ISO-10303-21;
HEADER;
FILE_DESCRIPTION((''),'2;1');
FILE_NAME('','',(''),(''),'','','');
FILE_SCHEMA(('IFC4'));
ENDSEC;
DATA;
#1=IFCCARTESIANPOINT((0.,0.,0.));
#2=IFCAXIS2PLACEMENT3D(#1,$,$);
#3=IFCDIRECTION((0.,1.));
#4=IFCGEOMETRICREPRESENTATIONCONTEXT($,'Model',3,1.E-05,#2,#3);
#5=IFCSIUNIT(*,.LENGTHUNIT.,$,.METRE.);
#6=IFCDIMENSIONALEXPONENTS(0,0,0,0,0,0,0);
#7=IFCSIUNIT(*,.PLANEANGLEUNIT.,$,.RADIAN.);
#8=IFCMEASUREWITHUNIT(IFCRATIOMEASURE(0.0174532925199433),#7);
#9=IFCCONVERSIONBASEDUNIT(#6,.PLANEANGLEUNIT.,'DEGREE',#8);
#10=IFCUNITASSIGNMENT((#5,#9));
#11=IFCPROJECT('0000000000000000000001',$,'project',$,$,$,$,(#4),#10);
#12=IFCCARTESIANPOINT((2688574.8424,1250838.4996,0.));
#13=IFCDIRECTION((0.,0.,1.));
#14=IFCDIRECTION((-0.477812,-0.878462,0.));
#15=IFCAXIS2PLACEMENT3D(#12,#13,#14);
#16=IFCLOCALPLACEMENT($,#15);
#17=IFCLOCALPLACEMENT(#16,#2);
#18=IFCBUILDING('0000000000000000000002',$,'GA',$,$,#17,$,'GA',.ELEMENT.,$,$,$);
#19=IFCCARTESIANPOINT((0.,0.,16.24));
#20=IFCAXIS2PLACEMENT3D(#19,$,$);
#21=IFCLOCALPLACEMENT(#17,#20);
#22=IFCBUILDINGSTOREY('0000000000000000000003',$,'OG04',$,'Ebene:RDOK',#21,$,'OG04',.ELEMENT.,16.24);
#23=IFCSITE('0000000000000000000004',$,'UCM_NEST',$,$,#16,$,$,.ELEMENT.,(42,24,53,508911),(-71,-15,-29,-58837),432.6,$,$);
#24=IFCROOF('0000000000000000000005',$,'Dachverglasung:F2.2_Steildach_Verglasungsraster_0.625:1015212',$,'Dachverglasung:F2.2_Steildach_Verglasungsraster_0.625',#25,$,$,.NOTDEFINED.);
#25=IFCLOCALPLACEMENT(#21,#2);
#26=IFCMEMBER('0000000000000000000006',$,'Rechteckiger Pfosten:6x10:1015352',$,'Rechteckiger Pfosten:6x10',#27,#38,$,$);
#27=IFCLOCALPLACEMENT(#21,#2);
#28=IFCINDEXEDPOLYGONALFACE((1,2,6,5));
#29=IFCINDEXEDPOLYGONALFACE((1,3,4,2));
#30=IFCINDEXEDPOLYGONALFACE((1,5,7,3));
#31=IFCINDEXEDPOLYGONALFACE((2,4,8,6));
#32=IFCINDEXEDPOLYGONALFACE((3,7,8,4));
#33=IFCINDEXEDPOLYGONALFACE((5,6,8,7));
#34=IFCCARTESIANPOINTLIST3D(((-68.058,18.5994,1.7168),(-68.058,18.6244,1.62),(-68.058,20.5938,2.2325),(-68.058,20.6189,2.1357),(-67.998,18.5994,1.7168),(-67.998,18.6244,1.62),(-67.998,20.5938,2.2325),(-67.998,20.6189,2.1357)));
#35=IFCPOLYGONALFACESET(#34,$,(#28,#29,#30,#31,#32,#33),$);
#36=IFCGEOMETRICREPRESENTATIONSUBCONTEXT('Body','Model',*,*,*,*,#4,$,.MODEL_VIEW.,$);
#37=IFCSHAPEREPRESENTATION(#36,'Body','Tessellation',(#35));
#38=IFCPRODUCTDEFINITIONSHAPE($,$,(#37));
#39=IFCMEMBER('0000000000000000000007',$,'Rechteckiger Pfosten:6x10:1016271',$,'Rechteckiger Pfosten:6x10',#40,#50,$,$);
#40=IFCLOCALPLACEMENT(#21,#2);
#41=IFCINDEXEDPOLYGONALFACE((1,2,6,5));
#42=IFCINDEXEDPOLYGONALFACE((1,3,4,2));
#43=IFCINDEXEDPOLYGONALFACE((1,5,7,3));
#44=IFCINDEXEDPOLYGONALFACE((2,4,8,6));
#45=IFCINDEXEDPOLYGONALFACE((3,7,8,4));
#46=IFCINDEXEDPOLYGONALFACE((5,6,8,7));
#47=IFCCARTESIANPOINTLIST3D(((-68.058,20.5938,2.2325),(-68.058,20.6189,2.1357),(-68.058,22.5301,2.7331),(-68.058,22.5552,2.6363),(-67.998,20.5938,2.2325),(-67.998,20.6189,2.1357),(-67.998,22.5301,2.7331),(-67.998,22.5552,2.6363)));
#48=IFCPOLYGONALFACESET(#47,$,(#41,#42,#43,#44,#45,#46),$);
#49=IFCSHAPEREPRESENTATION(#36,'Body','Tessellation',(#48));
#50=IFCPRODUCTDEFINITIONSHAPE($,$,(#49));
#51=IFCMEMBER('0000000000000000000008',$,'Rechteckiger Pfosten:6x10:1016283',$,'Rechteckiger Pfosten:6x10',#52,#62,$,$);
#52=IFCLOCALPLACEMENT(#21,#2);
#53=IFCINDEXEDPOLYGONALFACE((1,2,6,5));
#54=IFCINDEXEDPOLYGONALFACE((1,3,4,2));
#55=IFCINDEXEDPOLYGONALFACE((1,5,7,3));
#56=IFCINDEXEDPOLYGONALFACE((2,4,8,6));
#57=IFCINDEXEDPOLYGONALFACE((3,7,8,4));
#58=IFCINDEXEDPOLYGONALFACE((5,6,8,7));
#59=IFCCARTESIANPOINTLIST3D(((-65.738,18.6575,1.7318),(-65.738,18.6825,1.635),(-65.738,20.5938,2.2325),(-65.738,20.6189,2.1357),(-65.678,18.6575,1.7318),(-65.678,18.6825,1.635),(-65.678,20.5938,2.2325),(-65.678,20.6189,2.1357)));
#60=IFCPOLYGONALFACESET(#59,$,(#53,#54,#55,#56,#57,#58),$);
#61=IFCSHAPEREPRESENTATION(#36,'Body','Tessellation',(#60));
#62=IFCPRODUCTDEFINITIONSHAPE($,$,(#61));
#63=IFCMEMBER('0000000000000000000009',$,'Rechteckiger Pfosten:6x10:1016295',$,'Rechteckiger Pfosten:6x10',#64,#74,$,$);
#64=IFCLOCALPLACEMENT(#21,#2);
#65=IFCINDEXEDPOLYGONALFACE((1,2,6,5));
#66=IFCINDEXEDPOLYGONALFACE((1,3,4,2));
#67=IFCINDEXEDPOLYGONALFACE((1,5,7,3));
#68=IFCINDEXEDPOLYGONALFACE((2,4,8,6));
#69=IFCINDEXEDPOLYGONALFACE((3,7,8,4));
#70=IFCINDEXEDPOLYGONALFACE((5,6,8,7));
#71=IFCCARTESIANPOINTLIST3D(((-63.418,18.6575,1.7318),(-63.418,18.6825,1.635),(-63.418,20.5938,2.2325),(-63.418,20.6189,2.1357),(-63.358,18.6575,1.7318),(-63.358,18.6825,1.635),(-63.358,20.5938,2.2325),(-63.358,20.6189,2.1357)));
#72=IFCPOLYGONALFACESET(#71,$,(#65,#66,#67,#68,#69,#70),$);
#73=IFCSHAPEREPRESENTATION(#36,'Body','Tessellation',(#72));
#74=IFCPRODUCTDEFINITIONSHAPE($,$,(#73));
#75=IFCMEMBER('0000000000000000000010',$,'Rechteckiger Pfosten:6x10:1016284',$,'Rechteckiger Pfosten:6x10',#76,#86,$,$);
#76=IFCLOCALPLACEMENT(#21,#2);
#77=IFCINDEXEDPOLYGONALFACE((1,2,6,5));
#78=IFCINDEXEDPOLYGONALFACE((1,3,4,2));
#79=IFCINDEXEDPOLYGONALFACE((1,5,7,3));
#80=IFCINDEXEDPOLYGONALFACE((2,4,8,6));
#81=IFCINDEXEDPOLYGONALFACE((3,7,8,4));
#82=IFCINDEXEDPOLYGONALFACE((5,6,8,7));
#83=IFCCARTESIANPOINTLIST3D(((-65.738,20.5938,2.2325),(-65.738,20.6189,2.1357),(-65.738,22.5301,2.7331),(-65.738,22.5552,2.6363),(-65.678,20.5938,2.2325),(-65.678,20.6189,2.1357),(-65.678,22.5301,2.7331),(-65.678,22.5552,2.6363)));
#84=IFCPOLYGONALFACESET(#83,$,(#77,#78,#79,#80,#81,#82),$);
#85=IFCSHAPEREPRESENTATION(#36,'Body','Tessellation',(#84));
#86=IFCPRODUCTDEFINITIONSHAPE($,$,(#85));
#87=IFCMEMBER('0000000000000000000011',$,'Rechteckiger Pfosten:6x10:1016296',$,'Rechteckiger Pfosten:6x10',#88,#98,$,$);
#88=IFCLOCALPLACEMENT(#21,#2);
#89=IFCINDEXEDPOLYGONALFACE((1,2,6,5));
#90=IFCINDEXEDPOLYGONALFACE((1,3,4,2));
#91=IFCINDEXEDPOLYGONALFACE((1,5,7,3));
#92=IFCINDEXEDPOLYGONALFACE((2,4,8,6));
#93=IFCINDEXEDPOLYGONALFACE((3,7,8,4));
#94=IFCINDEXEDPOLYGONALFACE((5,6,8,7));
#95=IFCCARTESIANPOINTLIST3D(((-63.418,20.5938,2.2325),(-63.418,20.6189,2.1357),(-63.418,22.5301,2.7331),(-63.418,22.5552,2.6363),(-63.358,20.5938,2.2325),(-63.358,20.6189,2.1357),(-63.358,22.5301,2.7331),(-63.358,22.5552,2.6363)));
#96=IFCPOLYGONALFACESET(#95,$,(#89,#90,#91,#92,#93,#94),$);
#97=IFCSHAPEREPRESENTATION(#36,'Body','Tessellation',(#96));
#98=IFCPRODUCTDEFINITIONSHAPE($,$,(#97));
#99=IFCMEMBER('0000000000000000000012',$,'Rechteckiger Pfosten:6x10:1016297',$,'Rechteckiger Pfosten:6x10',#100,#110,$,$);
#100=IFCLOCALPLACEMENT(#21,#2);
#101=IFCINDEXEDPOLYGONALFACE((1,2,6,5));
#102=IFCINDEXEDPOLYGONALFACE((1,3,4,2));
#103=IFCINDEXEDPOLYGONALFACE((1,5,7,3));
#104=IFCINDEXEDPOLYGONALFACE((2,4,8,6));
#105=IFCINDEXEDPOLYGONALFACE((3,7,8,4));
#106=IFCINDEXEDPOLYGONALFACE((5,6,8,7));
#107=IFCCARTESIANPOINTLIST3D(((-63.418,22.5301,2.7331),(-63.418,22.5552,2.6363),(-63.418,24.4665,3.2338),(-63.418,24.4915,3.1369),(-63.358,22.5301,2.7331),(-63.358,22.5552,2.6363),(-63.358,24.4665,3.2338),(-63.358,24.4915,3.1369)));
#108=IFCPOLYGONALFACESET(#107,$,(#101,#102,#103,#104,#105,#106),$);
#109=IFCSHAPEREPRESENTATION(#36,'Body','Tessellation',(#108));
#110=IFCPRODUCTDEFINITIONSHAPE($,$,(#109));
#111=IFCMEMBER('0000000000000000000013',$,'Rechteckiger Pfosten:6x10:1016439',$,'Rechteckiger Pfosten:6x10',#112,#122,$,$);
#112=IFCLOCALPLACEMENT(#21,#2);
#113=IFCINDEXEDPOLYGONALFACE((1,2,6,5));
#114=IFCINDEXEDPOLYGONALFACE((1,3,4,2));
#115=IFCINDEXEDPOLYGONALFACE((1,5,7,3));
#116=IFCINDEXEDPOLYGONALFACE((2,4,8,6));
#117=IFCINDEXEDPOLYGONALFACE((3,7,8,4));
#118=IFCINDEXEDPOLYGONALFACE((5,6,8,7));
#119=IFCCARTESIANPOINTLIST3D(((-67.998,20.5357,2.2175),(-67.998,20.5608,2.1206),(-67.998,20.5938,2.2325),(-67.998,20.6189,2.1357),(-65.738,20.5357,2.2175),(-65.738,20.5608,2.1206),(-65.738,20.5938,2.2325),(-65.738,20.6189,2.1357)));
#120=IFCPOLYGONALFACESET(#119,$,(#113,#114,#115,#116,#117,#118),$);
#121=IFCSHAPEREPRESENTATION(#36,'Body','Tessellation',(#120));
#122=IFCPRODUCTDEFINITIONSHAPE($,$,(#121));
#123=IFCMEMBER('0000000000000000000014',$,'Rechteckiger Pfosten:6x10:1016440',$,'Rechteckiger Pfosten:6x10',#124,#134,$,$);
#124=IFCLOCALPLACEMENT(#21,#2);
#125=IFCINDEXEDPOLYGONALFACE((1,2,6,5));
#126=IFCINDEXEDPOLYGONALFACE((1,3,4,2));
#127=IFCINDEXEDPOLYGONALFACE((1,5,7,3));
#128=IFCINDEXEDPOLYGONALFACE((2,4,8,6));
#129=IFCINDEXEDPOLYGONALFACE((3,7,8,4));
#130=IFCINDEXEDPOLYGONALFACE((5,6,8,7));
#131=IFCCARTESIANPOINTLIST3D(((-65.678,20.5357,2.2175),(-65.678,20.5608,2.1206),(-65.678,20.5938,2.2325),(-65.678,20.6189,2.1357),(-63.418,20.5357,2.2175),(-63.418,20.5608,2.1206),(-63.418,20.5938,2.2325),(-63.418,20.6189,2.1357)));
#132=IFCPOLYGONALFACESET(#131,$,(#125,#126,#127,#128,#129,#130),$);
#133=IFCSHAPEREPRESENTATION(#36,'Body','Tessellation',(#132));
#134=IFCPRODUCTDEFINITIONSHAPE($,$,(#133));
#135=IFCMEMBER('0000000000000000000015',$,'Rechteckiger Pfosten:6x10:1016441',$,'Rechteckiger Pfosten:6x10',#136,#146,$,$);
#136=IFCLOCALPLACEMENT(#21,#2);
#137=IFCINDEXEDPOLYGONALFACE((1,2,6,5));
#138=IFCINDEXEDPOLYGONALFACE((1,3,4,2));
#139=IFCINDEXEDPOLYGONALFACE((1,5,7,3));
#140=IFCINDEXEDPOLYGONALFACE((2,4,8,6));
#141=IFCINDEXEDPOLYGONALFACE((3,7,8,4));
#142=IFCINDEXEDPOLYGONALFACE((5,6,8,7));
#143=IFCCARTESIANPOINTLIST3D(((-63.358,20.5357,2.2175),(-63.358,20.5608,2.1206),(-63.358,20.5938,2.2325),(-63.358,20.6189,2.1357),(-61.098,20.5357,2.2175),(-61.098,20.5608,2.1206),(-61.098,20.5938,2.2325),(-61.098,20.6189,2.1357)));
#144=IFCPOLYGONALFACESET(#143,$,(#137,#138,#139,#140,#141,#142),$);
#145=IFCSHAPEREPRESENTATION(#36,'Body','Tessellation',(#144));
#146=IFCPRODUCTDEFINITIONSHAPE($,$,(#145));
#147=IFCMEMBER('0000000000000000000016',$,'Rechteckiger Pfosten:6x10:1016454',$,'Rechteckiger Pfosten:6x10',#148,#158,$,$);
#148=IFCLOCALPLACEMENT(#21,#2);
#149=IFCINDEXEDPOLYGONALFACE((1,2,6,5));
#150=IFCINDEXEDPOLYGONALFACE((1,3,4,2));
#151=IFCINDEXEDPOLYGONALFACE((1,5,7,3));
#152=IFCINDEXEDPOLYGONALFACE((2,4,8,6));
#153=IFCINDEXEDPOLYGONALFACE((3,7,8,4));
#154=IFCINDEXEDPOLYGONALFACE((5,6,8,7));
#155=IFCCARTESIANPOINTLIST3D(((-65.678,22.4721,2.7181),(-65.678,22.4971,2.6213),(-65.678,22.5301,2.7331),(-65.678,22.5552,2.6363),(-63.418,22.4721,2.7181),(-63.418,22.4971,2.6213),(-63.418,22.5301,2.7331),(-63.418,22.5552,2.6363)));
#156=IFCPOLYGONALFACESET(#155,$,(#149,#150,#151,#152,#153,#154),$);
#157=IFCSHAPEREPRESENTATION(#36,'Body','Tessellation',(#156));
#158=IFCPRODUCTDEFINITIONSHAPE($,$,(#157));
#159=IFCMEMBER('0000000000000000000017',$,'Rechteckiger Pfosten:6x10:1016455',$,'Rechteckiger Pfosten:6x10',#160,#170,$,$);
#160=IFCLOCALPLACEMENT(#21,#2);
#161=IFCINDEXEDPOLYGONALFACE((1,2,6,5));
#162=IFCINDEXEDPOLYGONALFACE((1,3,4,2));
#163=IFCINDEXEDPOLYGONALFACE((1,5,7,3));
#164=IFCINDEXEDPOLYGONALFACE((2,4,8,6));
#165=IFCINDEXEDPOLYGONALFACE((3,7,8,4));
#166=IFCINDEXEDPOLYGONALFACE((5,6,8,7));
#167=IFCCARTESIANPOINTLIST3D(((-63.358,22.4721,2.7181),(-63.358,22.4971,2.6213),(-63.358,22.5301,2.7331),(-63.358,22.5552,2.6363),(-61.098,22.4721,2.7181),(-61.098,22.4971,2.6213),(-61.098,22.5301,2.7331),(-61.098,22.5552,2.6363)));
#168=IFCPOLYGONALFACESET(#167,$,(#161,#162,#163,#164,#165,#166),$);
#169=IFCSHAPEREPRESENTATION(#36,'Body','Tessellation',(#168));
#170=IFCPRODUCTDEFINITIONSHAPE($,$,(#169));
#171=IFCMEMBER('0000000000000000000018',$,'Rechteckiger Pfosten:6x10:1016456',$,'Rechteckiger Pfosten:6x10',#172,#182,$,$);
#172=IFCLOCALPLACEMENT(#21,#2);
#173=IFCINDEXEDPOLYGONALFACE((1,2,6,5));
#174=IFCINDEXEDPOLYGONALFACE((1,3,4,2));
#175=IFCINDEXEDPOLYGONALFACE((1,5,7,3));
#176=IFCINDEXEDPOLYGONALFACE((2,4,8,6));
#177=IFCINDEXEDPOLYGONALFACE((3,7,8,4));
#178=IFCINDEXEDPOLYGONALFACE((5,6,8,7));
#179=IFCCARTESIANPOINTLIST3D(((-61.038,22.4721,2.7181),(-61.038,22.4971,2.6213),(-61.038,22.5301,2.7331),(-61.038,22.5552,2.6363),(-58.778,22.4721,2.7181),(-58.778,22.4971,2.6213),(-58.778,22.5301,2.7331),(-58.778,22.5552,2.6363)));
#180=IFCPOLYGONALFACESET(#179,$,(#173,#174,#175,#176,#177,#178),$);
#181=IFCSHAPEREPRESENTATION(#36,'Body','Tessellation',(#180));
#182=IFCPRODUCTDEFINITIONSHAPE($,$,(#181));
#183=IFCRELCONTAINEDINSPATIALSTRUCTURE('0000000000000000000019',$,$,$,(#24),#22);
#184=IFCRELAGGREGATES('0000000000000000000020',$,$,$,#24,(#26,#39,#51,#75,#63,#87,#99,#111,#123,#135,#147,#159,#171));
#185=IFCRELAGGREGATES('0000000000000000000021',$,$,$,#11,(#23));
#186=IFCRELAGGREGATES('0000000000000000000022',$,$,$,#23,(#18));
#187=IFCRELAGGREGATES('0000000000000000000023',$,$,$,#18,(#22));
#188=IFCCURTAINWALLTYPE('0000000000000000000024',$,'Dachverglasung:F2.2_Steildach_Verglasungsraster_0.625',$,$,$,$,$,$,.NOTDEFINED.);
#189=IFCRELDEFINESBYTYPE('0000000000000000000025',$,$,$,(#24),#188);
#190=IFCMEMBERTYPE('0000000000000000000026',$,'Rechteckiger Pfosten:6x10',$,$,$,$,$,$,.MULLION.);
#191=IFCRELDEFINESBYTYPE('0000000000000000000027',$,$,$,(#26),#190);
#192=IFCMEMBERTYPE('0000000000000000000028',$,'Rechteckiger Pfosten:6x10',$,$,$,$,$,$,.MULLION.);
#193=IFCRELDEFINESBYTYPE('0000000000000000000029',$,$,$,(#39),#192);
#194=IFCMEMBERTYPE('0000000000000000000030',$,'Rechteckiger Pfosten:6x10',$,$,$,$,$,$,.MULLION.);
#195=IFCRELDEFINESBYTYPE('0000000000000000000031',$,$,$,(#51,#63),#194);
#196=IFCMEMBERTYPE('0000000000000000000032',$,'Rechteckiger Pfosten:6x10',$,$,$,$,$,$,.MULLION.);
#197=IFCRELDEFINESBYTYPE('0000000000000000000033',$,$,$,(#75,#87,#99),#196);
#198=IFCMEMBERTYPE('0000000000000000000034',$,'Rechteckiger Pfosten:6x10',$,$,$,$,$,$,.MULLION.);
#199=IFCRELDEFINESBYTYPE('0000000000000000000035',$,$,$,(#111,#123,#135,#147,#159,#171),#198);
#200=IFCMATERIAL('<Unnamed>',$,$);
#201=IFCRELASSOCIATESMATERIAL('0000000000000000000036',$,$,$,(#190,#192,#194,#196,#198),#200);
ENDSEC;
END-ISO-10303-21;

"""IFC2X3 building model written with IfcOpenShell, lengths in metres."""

from ifc_helpers import new_model, entity, si_unit, converted_unit, direction, frame, origin, origin_2d_with_axis, place, context, subcontext, project, spatial, rectangle, extrude, source, transform, mapped, material, type_object, type_shapes, element, aggregate, save


model = new_model("IFC2X3")

# Units and contexts
model_context = context("Model", 3, precision=1e-05, world=origin(), true_north=direction((0.0, 1.0)))
body_context = subcontext(model_context, "Body", "Model", "MODEL_VIEW")
ifc_project = project(units=[si_unit("LENGTHUNIT", "METRE"), converted_unit("PLANEANGLEUNIT", "DEGREE", entity("IfcRatioMeasure", 0.0174532925199433), si_unit("PLANEANGLEUNIT", "RADIAN"), dimensions=[0, 0, 0, 0, 0, 0, 0])], contexts=[model_context])

# Site, building, storey
site_placement = place(None, frame((2688574.8424, 1250838.4996, 0.0), z_axis=(0.0, 0.0, 1.0), x_axis=(-0.477812, -0.878462, 0.0)))
site = spatial("IfcSite", under=ifc_project, at=site_placement, Name="UCM_NEST", CompositionType="ELEMENT", RefLatitude=(42, 24, 53, 508911), RefLongitude=(-71, -15, -29, -58837), RefElevation=432.6)
building_placement = place(site_placement, origin())
building = spatial("IfcBuilding", under=site, at=building_placement, Name="GA", LongName="GA", CompositionType="ELEMENT")
storey_placement = place(building_placement, frame((0.0, 0.0, 16.24)))
storey = spatial("IfcBuildingStorey", under=building, at=storey_placement, Name="OG04", ObjectType="Ebene:RDOK", LongName="OG04", CompositionType="ELEMENT", Elevation=16.24)

# Roof, members
curtain_wall_type = type_object("IfcCurtainWallType", Name="Dachverglasung:F2.2_Steildach_Verglasungsraster_0.625", PredefinedType="NOTDEFINED")
roof_placement = place(storey_placement, frame((0.0, 0.0, -16.24)))
roof = element("IfcRoof", 1, at=roof_placement, inside=storey, type_object=curtain_wall_type, Name="Dachverglasung:F2.2_Steildach_Verglasungsraster_0.625:1015212", ObjectType="Dachverglasung:F2.2_Steildach_Verglasungsraster_0.625", ShapeType="NOTDEFINED")
ifc_material_1 = material(Name="<Unnamed>")
member_type_1 = type_object("IfcMemberType", Name="Rechteckiger Pfosten:6x10", PredefinedType="MULLION", material=ifc_material_1)
shared_shape_1 = source(origin(), body_context, "Body", "SweptSolid", [
    extrude(rectangle(XDim=0.1, YDim=0.06, at=origin_2d_with_axis()), frame((-0.03, -0.05, -2.06), z_axis=(0.0, 0.0, 1.0), x_axis=(0.0, -1.0, 0.0)), (0.0, 0.0, 1.0), 2.06),
])
type_shapes(member_type_1, [shared_shape_1])
member_1_placement = place(roof_placement, frame((-68.058, 18.6244, 17.86), z_axis=(0.0, -0.968163, -0.250322), x_axis=(-1.0, 0.0, 0.0)))
member_1 = element("IfcMember", 2, at=member_1_placement, type_object=member_type_1, Name="Rechteckiger Pfosten:6x10:1015352", ObjectType="Rechteckiger Pfosten:6x10", context=body_context, shape_type="MappedRepresentation", body=[
    mapped(shared_shape_1, transform((0.0, 0.0, 0.0), scale=1.0)),
])
member_type_2 = type_object("IfcMemberType", Name="Rechteckiger Pfosten:6x10", PredefinedType="MULLION", material=ifc_material_1)
shared_shape_2 = source(origin(), body_context, "Body", "SweptSolid", [
    extrude(rectangle(XDim=0.1, YDim=0.06, at=origin_2d_with_axis()), frame((-0.03, -0.05, -2.0), z_axis=(0.0, 0.0, 1.0), x_axis=(0.0, -1.0, 0.0)), (0.0, 0.0, 1.0), 2.0),
])
type_shapes(member_type_2, [shared_shape_2])
member_2_placement = place(roof_placement, frame((-68.058, 20.6189, 18.3757), z_axis=(0.0, -0.968163, -0.250322), x_axis=(-1.0, 0.0, 0.0)))
member_2 = element("IfcMember", 3, at=member_2_placement, type_object=member_type_2, Name="Rechteckiger Pfosten:6x10:1016271", ObjectType="Rechteckiger Pfosten:6x10", context=body_context, shape_type="MappedRepresentation", body=[
    mapped(shared_shape_2, transform((0.0, 0.0, 0.0), scale=1.0)),
])
member_type_3 = type_object("IfcMemberType", Name="Rechteckiger Pfosten:6x10", PredefinedType="MULLION", material=ifc_material_1)
shared_shape_3 = source(origin(), body_context, "Body", "SweptSolid", [
    extrude(rectangle(XDim=0.1, YDim=0.06, at=origin_2d_with_axis()), frame((-0.03, -0.05, -2.0), z_axis=(0.0, 0.0, 1.0), x_axis=(0.0, -1.0, 0.0)), (0.0, 0.0, 1.0), 2.0),
])
type_shapes(member_type_3, [shared_shape_3])
member_3_placement = place(roof_placement, frame((-65.678, 20.6189, 18.3757), z_axis=(0.0, 0.968163, 0.250322), x_axis=(1.0, 0.0, 0.0)))
member_3 = element("IfcMember", 4, at=member_3_placement, type_object=member_type_3, Name="Rechteckiger Pfosten:6x10:1016283", ObjectType="Rechteckiger Pfosten:6x10", context=body_context, shape_type="MappedRepresentation", body=[
    mapped(shared_shape_3, transform((0.0, 0.0, 0.0), scale=1.0)),
])
member_4_placement = place(roof_placement, frame((-63.358, 20.6189, 18.3757), z_axis=(0.0, 0.968163, 0.250322), x_axis=(1.0, 0.0, 0.0)))
member_4 = element("IfcMember", 5, at=member_4_placement, type_object=member_type_3, Name="Rechteckiger Pfosten:6x10:1016295", ObjectType="Rechteckiger Pfosten:6x10", context=body_context, shape_type="MappedRepresentation", body=[
    mapped(shared_shape_3, transform((0.0, 0.0, 0.0), scale=1.0)),
])
member_type_4 = type_object("IfcMemberType", Name="Rechteckiger Pfosten:6x10", PredefinedType="MULLION", material=ifc_material_1)
shared_shape_4 = source(origin(), body_context, "Body", "SweptSolid", [
    extrude(rectangle(XDim=0.1, YDim=0.06, at=origin_2d_with_axis()), frame((-0.03, -0.05, -2.0), z_axis=(0.0, 0.0, 1.0), x_axis=(0.0, -1.0, 0.0)), (0.0, 0.0, 1.0), 2.0),
])
type_shapes(member_type_4, [shared_shape_4])
member_5_placement = place(roof_placement, frame((-65.678, 22.5552, 18.8763), z_axis=(0.0, 0.968163, 0.250322), x_axis=(1.0, 0.0, 0.0)))
member_5 = element("IfcMember", 6, at=member_5_placement, type_object=member_type_4, Name="Rechteckiger Pfosten:6x10:1016284", ObjectType="Rechteckiger Pfosten:6x10", context=body_context, shape_type="MappedRepresentation", body=[
    mapped(shared_shape_4, transform((0.0, 0.0, 0.0), scale=1.0)),
])
member_6_placement = place(roof_placement, frame((-63.358, 22.5552, 18.8763), z_axis=(0.0, 0.968163, 0.250322), x_axis=(1.0, 0.0, 0.0)))
member_6 = element("IfcMember", 7, at=member_6_placement, type_object=member_type_4, Name="Rechteckiger Pfosten:6x10:1016296", ObjectType="Rechteckiger Pfosten:6x10", context=body_context, shape_type="MappedRepresentation", body=[
    mapped(shared_shape_4, transform((0.0, 0.0, 0.0), scale=1.0)),
])
member_7_placement = place(roof_placement, frame((-63.358, 24.4915, 19.3769), z_axis=(0.0, 0.968163, 0.250322), x_axis=(1.0, 0.0, 0.0)))
member_7 = element("IfcMember", 8, at=member_7_placement, type_object=member_type_4, Name="Rechteckiger Pfosten:6x10:1016297", ObjectType="Rechteckiger Pfosten:6x10", context=body_context, shape_type="MappedRepresentation", body=[
    mapped(shared_shape_4, transform((0.0, 0.0, 0.0), scale=1.0)),
])
member_type_5 = type_object("IfcMemberType", Name="Rechteckiger Pfosten:6x10", PredefinedType="MULLION", material=ifc_material_1)
shared_shape_5 = source(origin(), body_context, "Body", "SweptSolid", [
    extrude(rectangle(XDim=0.1, YDim=0.06, at=origin_2d_with_axis()), frame((-0.03, -0.05, -2.26), z_axis=(0.0, 0.0, 1.0), x_axis=(0.0, -1.0, 0.0)), (0.0, 0.0, 1.0), 2.26),
])
type_shapes(member_type_5, [shared_shape_5])
member_8_placement = place(roof_placement, frame((-67.998, 20.6189, 18.3757), z_axis=(-1.0, 0.0, 0.0), x_axis=(0.0, 0.968163, 0.250322)))
member_8 = element("IfcMember", 9, at=member_8_placement, type_object=member_type_5, Name="Rechteckiger Pfosten:6x10:1016439", ObjectType="Rechteckiger Pfosten:6x10", context=body_context, shape_type="MappedRepresentation", body=[
    mapped(shared_shape_5, transform((0.0, 0.0, 0.0), scale=1.0)),
])
member_9_placement = place(roof_placement, frame((-65.678, 20.6189, 18.3757), z_axis=(-1.0, 0.0, 0.0), x_axis=(0.0, 0.968163, 0.250322)))
member_9 = element("IfcMember", 10, at=member_9_placement, type_object=member_type_5, Name="Rechteckiger Pfosten:6x10:1016440", ObjectType="Rechteckiger Pfosten:6x10", context=body_context, shape_type="MappedRepresentation", body=[
    mapped(shared_shape_5, transform((0.0, 0.0, 0.0), scale=1.0)),
])
member_10_placement = place(roof_placement, frame((-63.358, 20.6189, 18.3757), z_axis=(-1.0, 0.0, 0.0), x_axis=(0.0, 0.968163, 0.250322)))
member_10 = element("IfcMember", 11, at=member_10_placement, type_object=member_type_5, Name="Rechteckiger Pfosten:6x10:1016441", ObjectType="Rechteckiger Pfosten:6x10", context=body_context, shape_type="MappedRepresentation", body=[
    mapped(shared_shape_5, transform((0.0, 0.0, 0.0), scale=1.0)),
])
member_11_placement = place(roof_placement, frame((-65.678, 22.5552, 18.8763), z_axis=(-1.0, 0.0, 0.0), x_axis=(0.0, 0.968163, 0.250322)))
member_11 = element("IfcMember", 12, at=member_11_placement, type_object=member_type_5, Name="Rechteckiger Pfosten:6x10:1016454", ObjectType="Rechteckiger Pfosten:6x10", context=body_context, shape_type="MappedRepresentation", body=[
    mapped(shared_shape_5, transform((0.0, 0.0, 0.0), scale=1.0)),
])
member_12_placement = place(roof_placement, frame((-63.358, 22.5552, 18.8763), z_axis=(-1.0, 0.0, 0.0), x_axis=(0.0, 0.968163, 0.250322)))
member_12 = element("IfcMember", 13, at=member_12_placement, type_object=member_type_5, Name="Rechteckiger Pfosten:6x10:1016455", ObjectType="Rechteckiger Pfosten:6x10", context=body_context, shape_type="MappedRepresentation", body=[
    mapped(shared_shape_5, transform((0.0, 0.0, 0.0), scale=1.0)),
])
member_13_placement = place(roof_placement, frame((-61.038, 22.5552, 18.8763), z_axis=(-1.0, 0.0, 0.0), x_axis=(0.0, 0.968163, 0.250322)))
member_13 = element("IfcMember", 14, at=member_13_placement, type_object=member_type_5, Name="Rechteckiger Pfosten:6x10:1016456", ObjectType="Rechteckiger Pfosten:6x10", context=body_context, shape_type="MappedRepresentation", body=[
    mapped(shared_shape_5, transform((0.0, 0.0, 0.0), scale=1.0)),
])
aggregate(roof, [member_1, member_2, member_3, member_5, member_4, member_6, member_7, member_8, member_9, member_10, member_11, member_12, member_13])

save(model, "model.ifc")
